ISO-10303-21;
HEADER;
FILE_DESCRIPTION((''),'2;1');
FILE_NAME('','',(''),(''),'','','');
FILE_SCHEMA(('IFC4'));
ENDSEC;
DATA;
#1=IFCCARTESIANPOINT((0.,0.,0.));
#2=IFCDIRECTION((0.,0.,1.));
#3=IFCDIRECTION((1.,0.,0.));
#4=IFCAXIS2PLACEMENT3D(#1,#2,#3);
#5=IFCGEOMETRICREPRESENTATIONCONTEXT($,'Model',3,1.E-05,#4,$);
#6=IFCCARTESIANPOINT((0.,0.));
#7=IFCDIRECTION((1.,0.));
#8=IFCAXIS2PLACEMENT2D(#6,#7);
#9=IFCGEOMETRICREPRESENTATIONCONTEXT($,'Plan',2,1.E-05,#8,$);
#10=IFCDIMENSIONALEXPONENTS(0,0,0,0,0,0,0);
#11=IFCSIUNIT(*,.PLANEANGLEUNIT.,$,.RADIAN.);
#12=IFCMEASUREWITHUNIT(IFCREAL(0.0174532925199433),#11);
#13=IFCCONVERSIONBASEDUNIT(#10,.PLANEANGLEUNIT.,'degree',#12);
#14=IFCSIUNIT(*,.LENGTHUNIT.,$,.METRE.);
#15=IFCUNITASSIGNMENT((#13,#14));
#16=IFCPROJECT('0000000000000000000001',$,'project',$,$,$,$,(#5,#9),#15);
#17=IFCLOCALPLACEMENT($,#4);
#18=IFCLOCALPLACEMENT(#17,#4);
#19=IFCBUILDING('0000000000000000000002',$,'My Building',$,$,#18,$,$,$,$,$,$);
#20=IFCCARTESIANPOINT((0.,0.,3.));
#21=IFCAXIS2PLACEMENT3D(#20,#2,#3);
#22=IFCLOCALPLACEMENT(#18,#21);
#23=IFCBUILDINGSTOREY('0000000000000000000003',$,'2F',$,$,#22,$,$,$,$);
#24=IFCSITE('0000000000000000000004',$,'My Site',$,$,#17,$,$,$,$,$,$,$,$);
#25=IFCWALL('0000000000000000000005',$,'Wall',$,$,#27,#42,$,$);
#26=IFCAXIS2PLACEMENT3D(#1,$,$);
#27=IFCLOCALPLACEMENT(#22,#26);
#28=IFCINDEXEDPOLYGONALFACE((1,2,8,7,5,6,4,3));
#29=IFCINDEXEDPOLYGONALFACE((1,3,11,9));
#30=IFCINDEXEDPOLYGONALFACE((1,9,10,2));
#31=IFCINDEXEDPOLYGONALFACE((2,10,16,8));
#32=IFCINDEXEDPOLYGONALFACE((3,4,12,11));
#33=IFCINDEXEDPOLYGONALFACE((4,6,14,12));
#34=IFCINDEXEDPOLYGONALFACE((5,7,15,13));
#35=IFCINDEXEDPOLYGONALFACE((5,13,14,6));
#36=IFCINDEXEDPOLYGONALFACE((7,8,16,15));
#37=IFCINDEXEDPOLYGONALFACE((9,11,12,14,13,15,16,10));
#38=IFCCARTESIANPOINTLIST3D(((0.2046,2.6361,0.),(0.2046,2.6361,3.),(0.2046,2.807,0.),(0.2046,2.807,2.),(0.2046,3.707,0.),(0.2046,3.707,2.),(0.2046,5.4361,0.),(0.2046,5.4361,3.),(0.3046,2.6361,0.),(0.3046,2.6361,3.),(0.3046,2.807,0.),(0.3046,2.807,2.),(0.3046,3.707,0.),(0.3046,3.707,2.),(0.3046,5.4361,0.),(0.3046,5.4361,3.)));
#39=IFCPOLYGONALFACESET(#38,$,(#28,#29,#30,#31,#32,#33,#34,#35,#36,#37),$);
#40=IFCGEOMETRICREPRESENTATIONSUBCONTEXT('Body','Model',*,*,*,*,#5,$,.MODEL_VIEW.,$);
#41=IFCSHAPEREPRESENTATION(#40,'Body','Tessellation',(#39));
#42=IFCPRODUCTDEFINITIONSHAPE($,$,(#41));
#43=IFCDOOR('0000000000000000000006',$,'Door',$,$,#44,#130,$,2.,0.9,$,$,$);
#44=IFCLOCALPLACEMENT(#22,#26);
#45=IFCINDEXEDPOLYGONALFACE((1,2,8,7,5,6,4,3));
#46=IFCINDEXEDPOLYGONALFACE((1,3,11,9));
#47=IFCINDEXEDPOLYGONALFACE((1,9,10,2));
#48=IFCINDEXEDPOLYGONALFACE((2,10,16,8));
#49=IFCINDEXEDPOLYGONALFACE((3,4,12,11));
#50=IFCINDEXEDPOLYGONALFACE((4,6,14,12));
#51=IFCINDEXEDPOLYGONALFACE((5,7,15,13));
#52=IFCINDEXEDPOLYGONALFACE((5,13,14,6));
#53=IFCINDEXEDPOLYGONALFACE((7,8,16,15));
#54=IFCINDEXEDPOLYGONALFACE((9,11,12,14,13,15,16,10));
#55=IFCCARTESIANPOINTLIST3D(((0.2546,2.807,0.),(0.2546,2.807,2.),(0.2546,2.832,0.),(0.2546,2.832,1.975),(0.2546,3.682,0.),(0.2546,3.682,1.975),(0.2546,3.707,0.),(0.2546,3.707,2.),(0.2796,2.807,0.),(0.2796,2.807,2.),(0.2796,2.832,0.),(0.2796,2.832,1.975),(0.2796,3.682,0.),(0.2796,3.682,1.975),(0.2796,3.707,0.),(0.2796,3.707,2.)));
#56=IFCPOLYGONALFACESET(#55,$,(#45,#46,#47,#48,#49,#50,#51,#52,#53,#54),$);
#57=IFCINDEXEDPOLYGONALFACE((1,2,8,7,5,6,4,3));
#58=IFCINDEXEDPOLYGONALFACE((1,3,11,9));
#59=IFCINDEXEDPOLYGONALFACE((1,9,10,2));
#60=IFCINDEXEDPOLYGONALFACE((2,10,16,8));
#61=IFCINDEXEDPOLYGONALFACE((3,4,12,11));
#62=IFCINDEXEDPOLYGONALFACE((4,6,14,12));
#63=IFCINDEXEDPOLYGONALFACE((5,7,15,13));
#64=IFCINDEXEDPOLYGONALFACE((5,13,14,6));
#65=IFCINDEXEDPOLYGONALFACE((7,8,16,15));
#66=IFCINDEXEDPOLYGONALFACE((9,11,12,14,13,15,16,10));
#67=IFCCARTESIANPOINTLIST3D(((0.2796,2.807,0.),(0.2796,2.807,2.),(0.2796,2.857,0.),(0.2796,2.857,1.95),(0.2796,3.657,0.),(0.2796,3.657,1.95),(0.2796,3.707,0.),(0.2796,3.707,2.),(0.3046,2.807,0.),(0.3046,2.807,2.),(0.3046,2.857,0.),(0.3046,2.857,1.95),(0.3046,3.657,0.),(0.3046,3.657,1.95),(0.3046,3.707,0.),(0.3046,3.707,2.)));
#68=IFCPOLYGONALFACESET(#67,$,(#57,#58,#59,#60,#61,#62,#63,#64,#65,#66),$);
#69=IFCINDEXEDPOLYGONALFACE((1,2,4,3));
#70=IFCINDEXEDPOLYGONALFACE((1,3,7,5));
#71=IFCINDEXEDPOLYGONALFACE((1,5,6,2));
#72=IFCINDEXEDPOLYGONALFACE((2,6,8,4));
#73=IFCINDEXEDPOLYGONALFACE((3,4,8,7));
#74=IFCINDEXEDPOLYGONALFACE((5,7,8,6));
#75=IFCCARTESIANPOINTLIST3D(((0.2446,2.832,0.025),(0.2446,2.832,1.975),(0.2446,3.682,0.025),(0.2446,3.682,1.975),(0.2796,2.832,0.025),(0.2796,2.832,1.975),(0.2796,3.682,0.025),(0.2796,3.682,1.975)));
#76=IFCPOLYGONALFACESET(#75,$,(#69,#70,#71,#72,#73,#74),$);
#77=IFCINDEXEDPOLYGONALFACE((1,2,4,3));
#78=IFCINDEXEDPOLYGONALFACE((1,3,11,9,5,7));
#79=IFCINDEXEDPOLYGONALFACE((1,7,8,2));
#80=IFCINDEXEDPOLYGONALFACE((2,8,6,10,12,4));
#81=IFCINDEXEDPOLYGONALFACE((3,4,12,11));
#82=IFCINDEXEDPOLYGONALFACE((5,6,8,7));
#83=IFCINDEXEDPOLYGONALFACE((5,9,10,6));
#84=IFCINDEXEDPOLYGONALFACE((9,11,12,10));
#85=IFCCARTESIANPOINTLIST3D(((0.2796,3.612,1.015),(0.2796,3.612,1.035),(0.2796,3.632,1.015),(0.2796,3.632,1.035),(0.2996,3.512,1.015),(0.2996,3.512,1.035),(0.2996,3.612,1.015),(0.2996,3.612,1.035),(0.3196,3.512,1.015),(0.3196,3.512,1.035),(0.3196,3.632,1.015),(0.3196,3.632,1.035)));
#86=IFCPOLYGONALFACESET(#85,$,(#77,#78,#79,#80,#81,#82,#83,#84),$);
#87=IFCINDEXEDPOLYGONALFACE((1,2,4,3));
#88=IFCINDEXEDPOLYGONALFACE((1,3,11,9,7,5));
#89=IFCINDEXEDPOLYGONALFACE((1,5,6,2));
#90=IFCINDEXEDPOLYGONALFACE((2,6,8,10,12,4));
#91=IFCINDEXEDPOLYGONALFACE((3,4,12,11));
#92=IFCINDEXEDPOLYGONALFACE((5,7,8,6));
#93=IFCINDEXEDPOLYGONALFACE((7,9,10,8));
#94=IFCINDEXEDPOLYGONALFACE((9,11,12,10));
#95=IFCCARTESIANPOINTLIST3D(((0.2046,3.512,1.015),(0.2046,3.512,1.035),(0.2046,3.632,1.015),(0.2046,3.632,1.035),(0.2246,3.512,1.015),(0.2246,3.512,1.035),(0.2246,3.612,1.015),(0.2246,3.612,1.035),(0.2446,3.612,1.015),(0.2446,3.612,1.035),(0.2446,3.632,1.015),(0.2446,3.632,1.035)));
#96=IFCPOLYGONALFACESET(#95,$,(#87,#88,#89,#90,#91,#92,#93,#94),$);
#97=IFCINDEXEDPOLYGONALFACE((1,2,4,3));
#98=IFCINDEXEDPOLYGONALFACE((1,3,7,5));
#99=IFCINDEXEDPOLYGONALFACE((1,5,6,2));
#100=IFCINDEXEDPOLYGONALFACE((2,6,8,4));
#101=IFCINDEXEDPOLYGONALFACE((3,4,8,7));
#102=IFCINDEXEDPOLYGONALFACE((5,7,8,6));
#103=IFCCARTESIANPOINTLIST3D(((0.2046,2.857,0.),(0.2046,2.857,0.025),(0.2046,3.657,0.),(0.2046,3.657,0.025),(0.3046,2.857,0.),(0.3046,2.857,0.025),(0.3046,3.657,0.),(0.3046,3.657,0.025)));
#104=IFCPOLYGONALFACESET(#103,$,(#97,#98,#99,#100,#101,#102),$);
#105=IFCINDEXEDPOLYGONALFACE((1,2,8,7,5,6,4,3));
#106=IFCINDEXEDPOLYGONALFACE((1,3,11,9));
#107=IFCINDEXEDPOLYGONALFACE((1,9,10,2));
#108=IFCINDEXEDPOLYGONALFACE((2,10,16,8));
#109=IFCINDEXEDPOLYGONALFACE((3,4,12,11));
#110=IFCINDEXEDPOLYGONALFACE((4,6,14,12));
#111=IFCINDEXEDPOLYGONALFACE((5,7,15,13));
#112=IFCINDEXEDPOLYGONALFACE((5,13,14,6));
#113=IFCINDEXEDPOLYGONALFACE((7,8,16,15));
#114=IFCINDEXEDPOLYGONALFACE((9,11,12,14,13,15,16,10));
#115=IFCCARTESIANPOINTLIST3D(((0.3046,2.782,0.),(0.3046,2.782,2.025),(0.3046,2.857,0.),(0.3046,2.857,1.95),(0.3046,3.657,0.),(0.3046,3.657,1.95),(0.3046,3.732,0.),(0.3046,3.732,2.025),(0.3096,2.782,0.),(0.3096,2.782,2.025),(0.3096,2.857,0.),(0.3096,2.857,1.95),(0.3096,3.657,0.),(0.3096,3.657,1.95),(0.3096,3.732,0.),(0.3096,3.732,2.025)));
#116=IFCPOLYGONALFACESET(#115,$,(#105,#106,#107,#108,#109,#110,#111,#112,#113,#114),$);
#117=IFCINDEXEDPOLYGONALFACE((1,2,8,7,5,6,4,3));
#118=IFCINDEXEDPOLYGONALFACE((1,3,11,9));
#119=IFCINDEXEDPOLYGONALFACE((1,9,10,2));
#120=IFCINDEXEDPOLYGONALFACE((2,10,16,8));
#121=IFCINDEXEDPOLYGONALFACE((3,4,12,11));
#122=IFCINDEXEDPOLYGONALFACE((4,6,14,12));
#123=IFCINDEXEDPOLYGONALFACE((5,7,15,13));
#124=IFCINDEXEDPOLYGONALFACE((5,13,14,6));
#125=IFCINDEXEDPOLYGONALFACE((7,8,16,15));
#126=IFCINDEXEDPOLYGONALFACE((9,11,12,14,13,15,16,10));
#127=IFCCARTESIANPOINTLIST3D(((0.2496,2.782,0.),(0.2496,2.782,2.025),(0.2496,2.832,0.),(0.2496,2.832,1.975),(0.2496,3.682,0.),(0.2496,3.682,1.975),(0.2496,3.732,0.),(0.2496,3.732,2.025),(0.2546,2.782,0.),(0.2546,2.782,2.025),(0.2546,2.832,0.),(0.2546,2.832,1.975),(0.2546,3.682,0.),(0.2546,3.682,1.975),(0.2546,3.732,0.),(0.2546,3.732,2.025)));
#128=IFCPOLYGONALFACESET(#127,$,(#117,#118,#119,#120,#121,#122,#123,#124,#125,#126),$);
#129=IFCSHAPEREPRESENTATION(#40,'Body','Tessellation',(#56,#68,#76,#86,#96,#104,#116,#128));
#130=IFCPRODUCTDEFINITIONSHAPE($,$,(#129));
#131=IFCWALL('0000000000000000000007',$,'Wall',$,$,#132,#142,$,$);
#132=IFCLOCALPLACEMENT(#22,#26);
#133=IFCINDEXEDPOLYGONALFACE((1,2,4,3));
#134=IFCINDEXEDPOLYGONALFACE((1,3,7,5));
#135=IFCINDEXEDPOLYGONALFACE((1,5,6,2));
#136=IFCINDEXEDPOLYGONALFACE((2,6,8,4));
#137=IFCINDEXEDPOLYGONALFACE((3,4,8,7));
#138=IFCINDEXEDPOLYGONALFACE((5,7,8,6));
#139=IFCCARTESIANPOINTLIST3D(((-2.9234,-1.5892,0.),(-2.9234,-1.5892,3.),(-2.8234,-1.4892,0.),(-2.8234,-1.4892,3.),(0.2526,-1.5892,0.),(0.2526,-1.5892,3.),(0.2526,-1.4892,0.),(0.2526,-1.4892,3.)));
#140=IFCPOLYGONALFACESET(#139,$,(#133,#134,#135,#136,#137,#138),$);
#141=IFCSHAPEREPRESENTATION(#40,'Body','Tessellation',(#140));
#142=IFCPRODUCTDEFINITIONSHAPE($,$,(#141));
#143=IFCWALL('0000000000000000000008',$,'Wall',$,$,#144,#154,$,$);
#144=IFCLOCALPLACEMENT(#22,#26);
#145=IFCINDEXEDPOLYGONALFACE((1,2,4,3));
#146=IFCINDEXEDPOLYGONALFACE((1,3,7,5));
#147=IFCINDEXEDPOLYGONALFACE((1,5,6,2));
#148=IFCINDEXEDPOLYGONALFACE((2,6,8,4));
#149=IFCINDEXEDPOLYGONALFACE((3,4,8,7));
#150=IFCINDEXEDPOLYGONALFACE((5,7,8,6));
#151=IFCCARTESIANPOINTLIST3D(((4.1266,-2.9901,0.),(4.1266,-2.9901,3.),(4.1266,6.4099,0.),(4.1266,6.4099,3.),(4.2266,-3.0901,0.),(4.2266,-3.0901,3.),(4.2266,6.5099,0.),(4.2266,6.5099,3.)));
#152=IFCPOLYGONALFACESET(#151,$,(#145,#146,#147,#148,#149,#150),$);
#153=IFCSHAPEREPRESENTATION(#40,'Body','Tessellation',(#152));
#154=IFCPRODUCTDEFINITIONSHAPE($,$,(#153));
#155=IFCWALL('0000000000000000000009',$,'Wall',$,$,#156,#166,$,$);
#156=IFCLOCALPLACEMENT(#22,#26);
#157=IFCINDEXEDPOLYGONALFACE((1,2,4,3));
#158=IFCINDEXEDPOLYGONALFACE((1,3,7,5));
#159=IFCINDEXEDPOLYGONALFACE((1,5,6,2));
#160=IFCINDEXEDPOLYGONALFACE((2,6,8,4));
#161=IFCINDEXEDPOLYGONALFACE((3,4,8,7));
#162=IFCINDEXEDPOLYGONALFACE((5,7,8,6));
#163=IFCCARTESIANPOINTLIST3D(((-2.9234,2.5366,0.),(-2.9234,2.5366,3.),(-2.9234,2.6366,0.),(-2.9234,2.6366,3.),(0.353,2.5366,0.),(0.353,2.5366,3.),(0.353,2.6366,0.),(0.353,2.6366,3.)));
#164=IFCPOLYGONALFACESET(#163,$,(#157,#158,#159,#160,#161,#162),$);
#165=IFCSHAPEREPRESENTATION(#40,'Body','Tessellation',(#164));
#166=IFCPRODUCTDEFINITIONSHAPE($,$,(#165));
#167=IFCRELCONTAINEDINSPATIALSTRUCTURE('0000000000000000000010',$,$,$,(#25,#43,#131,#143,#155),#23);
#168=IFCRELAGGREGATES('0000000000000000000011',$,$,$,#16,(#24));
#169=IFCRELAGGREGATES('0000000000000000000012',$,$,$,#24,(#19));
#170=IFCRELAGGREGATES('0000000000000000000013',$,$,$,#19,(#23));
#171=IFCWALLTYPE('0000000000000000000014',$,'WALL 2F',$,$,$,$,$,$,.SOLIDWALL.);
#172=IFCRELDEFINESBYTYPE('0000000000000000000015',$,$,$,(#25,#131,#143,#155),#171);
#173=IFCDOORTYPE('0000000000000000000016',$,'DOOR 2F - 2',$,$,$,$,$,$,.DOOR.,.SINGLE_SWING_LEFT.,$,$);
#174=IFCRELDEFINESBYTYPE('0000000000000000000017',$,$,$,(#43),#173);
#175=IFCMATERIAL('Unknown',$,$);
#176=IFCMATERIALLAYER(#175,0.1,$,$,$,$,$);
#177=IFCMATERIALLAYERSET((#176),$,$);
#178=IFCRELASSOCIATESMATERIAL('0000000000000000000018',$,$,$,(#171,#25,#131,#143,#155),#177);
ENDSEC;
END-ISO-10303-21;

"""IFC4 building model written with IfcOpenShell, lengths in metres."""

from ifc_helpers import new_model, entity, si_unit, converted_unit, frame, origin_with_axes, origin_2d_with_axis, place, context, subcontext, project, spatial, line, indexed_curve, outline, extrude, shape, source, transform, mapped, material, layer, layer_set, layer_usage, type_object, type_shapes, element, fill, save


model = new_model("IFC4")

# Units and contexts
model_context = context("Model", 3, precision=1e-05, world=origin_with_axes())
plan_context = context("Plan", 2, precision=1e-05, world=origin_2d_with_axis())
body_context_1 = subcontext(model_context, "Body", "Model", "MODEL_VIEW")
body_context_2 = subcontext(plan_context, "Body", "Plan", "PLAN_VIEW")
ifc_project = project(units=[converted_unit("PLANEANGLEUNIT", "degree", entity("IfcReal", 0.0174532925199433), si_unit("PLANEANGLEUNIT", "RADIAN"), dimensions=[0, 0, 0, 0, 0, 0, 0]), si_unit("LENGTHUNIT", "METRE")], contexts=[model_context, plan_context])

# Site, building, storey
site_placement = place(None, origin_with_axes())
site = spatial("IfcSite", under=ifc_project, at=site_placement, Name="My Site")
building_placement = place(site_placement, origin_with_axes())
building = spatial("IfcBuilding", under=site, at=building_placement, Name="My Building")
storey_placement = place(building_placement, frame((0.0, 0.0, 3.0), z_axis=(0.0, 0.0, 1.0), x_axis=(1.0, 0.0, 0.0)))
storey = spatial("IfcBuildingStorey", under=building, at=storey_placement, Name="2F")

# Shared definitions
ifc_material = material(Name="Unknown")

# Shared definitions
ifc_layer = layer(ifc_material, 0.1)
ifc_layer_set = layer_set([ifc_layer])
wall_type = type_object("IfcWallType", Name="WALL 2F", PredefinedType="SOLIDWALL", material=ifc_layer_set)

# Wall, opening, door
shared_shape_1 = source(origin_with_axes(), body_context_1, "Body", "SweptSolid", [
    extrude(outline(indexed_curve([(0.0, 0.0), (0.9, 0.0), (0.9, 2.0), (0.0, 2.0)], segments=[line(1, 2, 3, 4, 1)])), frame((0.0, -0.6, 0.0), z_axis=(0.0, -1.0, 0.0), x_axis=(1.0, 0.0, 0.0)), (0.0, 0.0, -1.0), 1.2),
])
door_type_1 = type_object("IfcDoorType", Name="DOOR 2F - 2", OperationType="SINGLE_SWING_LEFT", PredefinedType="DOOR")
shared_shape_2 = source(origin_with_axes(), body_context_1, "Body", "SweptSolid", [
    extrude(outline(indexed_curve([(0.0, 0.0), (0.0, 2.0), (0.9, 2.0), (0.9, 0.0), (0.875, 0.0), (0.875, 1.975), (0.025, 1.975), (0.025, 0.0)], segments=[line(1, 2, 3, 4, 5, 6, 7, 8, 1)])), frame((0.0, 0.025, 0.0), z_axis=(0.0, -1.0, 0.0), x_axis=(1.0, 0.0, 0.0)), (0.0, 0.0, -1.0), 0.025),
    extrude(outline(indexed_curve([(0.0, 0.0), (0.0, 2.0), (0.9, 2.0), (0.9, 0.0), (0.85, 0.0), (0.85, 1.95), (0.05, 1.95), (0.05, 0.0)], segments=[line(1, 2, 3, 4, 5, 6, 7, 8, 1)])), frame((0.0, 0.0, 0.0), z_axis=(0.0, -1.0, 0.0), x_axis=(1.0, 0.0, 0.0)), (0.0, 0.0, -1.0), 0.025),
    extrude(outline(indexed_curve([(0.0, 0.0), (0.85, 0.0), (0.85, 0.035), (0.0, 0.035)], segments=[line(1, 2, 3, 4, 1)])), frame((0.025, 0.025, 0.025), z_axis=(0.0, 0.0, 1.0), x_axis=(1.0, 0.0, 0.0)), (0.0, 0.0, 1.0), 1.95),
    extrude(outline(indexed_curve([(0.0, 0.0), (0.0, -0.04), (-0.12, -0.04), (-0.12, -0.02), (-0.02, -0.02), (-0.02, 0.0)], segments=[line(1, 2, 3, 4, 5, 6, 1)])), frame((0.825, 0.025, 1.015), z_axis=(0.0, 0.0, 1.0), x_axis=(1.0, 0.0, 0.0)), (0.0, 0.0, 1.0), 0.02),
    extrude(outline(indexed_curve([(0.0, 0.0), (0.0, 0.04), (-0.12, 0.04), (-0.12, 0.02), (-0.02, 0.02), (-0.02, 0.0)], segments=[line(1, 2, 3, 4, 5, 6, 1)])), frame((0.825, 0.06, 1.015), z_axis=(0.0, 0.0, 1.0), x_axis=(1.0, 0.0, 0.0)), (0.0, 0.0, 1.0), 0.02),
    extrude(outline(indexed_curve([(0.0, 0.0), (0.8, 0.0), (0.8, 0.1), (0.0, 0.1)], segments=[line(1, 2, 3, 4, 1)])), frame((0.05, 0.0, 0.0), z_axis=(0.0, 0.0, 1.0), x_axis=(1.0, 0.0, 0.0)), (0.0, 0.0, 1.0), 0.025),
    extrude(outline(indexed_curve([(0.0, 0.0), (0.0, 2.025), (0.95, 2.025), (0.95, 0.0), (0.875, 0.0), (0.875, 1.95), (0.075, 1.95), (0.075, 0.0)], segments=[line(1, 2, 3, 4, 5, 6, 7, 8, 1)])), frame((-0.025, -0.005, 0.0), z_axis=(0.0, -1.0, 0.0), x_axis=(1.0, 0.0, 0.0)), (0.0, 0.0, -1.0), 0.005),
    extrude(outline(indexed_curve([(0.0, 0.0), (0.0, 2.025), (0.95, 2.025), (0.95, 0.0), (0.9, 0.0), (0.9, 1.975), (0.05, 1.975), (0.05, 0.0)], segments=[line(1, 2, 3, 4, 5, 6, 7, 8, 1)])), frame((-0.025, 0.05, 0.0), z_axis=(0.0, -1.0, 0.0), x_axis=(1.0, 0.0, 0.0)), (0.0, 0.0, -1.0), 0.005),
])
shared_shape_3 = source(origin_with_axes(), body_context_2, "Body", "Curve2D", [
    entity("IfcIndexedPolyCurve", entity("IfcCartesianPointList2D", [[0.0, 0.0], [0.0, 0.05], [0.025, 0.05], [0.025, 0.025], [0.05, 0.025], [0.05, 0.0]]), [entity("IfcLineIndex", [1, 2, 3, 4, 5, 6, 1])]),
    entity("IfcIndexedPolyCurve", entity("IfcCartesianPointList2D", [[0.9, 0.0], [0.9, 0.05], [0.875, 0.05], [0.875, 0.025], [0.85, 0.025], [0.85, 0.0]]), [entity("IfcLineIndex", [1, 2, 3, 4, 5, 6, 1])]),
    entity("IfcTrimmedCurve", entity("IfcEllipse", entity("IfcAxis2Placement2D", entity("IfcCartesianPoint", [0.06, 0.05]), entity("IfcDirection", [1.0, 0.0])), 0.815, 0.85), [entity("IfcCartesianPoint", [0.875, 0.05])], [entity("IfcCartesianPoint", [0.06, 0.9])], True, "CARTESIAN"),
    entity("IfcIndexedPolyCurve", entity("IfcCartesianPointList2D", [[0.025, 0.05], [0.06, 0.05], [0.06, 0.9], [0.025, 0.9]]), [entity("IfcLineIndex", [1, 2, 3, 4, 1])]),
])
type_shapes(door_type_1, [shared_shape_2, shared_shape_3])
ifc_layer_usage_1 = layer_usage(ifc_layer_set, "AXIS2", "POSITIVE", 0.0)
wall_1_placement = place(storey_placement, frame((0.3046, 2.6361, 0.0), z_axis=(0.0, 0.0, 1.0), x_axis=(0.0, 1.0, 0.0)))
wall_1 = element("IfcWall", 1, at=wall_1_placement, inside=storey, type_object=wall_type, material=ifc_layer_usage_1, Name="Wall", context=body_context_1, shape_type="SweptSolid", body=[
    extrude(outline(indexed_curve([(0.0, 0.0), (0.0, 0.1), (2.8, 0.1), (2.8, 0.0)], segments=[line(1, 2, 3, 4, 1)])), origin_with_axes(), (0.0, 0.0, 1.0), 3.0),
])
opening_1_placement = place(wall_1_placement, frame((0.1709, 0.0, 0.0), z_axis=(0.0, 0.0, 1.0), x_axis=(1.0, 0.0, 0.0)))
opening_1 = element("IfcOpeningElement", 2, at=opening_1_placement, cuts=wall_1, PredefinedType="OPENING", context=body_context_1, shape_type="MappedRepresentation", body=[
    mapped(shared_shape_1, transform((0.0, 0.0, 0.0), x_axis=(1.0, 0.0, 0.0), y_axis=(0.0, 1.0, 0.0), z_axis=(0.0, 0.0, 1.0), scale=1.0)),
])
door_1_placement = place(opening_1_placement, origin_with_axes())
door_1 = element("IfcDoor", 3, at=door_1_placement, inside=storey, type_object=door_type_1, Name="Door", OverallHeight=2.0, OverallWidth=0.9, shapes=[
    shape(body_context_1, "Body", "MappedRepresentation", [mapped(shared_shape_2, transform((0.0, 0.0, 0.0), x_axis=(1.0, 0.0, 0.0), y_axis=(0.0, 1.0, 0.0), z_axis=(0.0, 0.0, 1.0), scale=1.0))]),
    shape(body_context_2, "Body", "MappedRepresentation", [mapped(shared_shape_3, transform((0.0, 0.0, 0.0), x_axis=(1.0, 0.0, 0.0), y_axis=(0.0, 1.0, 0.0), z_axis=(0.0, 0.0, 1.0), scale=1.0))]),
])
fill(opening_1, door_1)

# Walls
ifc_layer_usage_2 = layer_usage(ifc_layer_set, "AXIS2", "POSITIVE", 0.0)
wall_2_placement = place(storey_placement, frame((-2.9234, -1.5892, 0.0), z_axis=(0.0, 0.0, 1.0), x_axis=(1.0, 0.0, 0.0)))
element("IfcWall", 4, at=wall_2_placement, inside=storey, type_object=wall_type, material=ifc_layer_usage_2, Name="Wall", context=body_context_1, shape_type="SweptSolid", body=[
    extrude(outline(indexed_curve([(0.0, 0.0), (0.1, 0.1), (3.176, 0.1), (3.176, 0.0)], segments=[line(1, 2, 3, 4, 1)])), origin_with_axes(), (0.0, 0.0, 1.0), 3.0),
])
ifc_layer_usage_3 = layer_usage(ifc_layer_set, "AXIS2", "POSITIVE", 0.0)
wall_3_placement = place(storey_placement, frame((4.2266, -3.0901, 0.0), z_axis=(0.0, 0.0, 1.0), x_axis=(0.0, 1.0, 0.0)))
element("IfcWall", 5, at=wall_3_placement, inside=storey, type_object=wall_type, material=ifc_layer_usage_3, Name="Wall", context=body_context_1, shape_type="SweptSolid", body=[
    extrude(outline(indexed_curve([(0.0, 0.0), (0.1, 0.1), (9.5, 0.1), (9.6, 0.0)], segments=[line(1, 2, 3, 4, 1)])), origin_with_axes(), (0.0, 0.0, 1.0), 3.0),
])
ifc_layer_usage_4 = layer_usage(ifc_layer_set, "AXIS2", "POSITIVE", 0.0)
wall_4_placement = place(storey_placement, frame((0.353, 2.6366, 0.0), z_axis=(0.0, 0.0, 1.0), x_axis=(-1.0, 0.0, 0.0)))
element("IfcWall", 6, at=wall_4_placement, inside=storey, type_object=wall_type, material=ifc_layer_usage_4, Name="Wall", context=body_context_1, shape_type="SweptSolid", body=[
    extrude(outline(indexed_curve([(0.0, 0.0), (0.0, 0.1), (3.2764, 0.1), (3.2764, 0.0)], segments=[line(1, 2, 3, 4, 1)])), origin_with_axes(), (0.0, 0.0, 1.0), 3.0),
])

save(model, "model.ifc")
